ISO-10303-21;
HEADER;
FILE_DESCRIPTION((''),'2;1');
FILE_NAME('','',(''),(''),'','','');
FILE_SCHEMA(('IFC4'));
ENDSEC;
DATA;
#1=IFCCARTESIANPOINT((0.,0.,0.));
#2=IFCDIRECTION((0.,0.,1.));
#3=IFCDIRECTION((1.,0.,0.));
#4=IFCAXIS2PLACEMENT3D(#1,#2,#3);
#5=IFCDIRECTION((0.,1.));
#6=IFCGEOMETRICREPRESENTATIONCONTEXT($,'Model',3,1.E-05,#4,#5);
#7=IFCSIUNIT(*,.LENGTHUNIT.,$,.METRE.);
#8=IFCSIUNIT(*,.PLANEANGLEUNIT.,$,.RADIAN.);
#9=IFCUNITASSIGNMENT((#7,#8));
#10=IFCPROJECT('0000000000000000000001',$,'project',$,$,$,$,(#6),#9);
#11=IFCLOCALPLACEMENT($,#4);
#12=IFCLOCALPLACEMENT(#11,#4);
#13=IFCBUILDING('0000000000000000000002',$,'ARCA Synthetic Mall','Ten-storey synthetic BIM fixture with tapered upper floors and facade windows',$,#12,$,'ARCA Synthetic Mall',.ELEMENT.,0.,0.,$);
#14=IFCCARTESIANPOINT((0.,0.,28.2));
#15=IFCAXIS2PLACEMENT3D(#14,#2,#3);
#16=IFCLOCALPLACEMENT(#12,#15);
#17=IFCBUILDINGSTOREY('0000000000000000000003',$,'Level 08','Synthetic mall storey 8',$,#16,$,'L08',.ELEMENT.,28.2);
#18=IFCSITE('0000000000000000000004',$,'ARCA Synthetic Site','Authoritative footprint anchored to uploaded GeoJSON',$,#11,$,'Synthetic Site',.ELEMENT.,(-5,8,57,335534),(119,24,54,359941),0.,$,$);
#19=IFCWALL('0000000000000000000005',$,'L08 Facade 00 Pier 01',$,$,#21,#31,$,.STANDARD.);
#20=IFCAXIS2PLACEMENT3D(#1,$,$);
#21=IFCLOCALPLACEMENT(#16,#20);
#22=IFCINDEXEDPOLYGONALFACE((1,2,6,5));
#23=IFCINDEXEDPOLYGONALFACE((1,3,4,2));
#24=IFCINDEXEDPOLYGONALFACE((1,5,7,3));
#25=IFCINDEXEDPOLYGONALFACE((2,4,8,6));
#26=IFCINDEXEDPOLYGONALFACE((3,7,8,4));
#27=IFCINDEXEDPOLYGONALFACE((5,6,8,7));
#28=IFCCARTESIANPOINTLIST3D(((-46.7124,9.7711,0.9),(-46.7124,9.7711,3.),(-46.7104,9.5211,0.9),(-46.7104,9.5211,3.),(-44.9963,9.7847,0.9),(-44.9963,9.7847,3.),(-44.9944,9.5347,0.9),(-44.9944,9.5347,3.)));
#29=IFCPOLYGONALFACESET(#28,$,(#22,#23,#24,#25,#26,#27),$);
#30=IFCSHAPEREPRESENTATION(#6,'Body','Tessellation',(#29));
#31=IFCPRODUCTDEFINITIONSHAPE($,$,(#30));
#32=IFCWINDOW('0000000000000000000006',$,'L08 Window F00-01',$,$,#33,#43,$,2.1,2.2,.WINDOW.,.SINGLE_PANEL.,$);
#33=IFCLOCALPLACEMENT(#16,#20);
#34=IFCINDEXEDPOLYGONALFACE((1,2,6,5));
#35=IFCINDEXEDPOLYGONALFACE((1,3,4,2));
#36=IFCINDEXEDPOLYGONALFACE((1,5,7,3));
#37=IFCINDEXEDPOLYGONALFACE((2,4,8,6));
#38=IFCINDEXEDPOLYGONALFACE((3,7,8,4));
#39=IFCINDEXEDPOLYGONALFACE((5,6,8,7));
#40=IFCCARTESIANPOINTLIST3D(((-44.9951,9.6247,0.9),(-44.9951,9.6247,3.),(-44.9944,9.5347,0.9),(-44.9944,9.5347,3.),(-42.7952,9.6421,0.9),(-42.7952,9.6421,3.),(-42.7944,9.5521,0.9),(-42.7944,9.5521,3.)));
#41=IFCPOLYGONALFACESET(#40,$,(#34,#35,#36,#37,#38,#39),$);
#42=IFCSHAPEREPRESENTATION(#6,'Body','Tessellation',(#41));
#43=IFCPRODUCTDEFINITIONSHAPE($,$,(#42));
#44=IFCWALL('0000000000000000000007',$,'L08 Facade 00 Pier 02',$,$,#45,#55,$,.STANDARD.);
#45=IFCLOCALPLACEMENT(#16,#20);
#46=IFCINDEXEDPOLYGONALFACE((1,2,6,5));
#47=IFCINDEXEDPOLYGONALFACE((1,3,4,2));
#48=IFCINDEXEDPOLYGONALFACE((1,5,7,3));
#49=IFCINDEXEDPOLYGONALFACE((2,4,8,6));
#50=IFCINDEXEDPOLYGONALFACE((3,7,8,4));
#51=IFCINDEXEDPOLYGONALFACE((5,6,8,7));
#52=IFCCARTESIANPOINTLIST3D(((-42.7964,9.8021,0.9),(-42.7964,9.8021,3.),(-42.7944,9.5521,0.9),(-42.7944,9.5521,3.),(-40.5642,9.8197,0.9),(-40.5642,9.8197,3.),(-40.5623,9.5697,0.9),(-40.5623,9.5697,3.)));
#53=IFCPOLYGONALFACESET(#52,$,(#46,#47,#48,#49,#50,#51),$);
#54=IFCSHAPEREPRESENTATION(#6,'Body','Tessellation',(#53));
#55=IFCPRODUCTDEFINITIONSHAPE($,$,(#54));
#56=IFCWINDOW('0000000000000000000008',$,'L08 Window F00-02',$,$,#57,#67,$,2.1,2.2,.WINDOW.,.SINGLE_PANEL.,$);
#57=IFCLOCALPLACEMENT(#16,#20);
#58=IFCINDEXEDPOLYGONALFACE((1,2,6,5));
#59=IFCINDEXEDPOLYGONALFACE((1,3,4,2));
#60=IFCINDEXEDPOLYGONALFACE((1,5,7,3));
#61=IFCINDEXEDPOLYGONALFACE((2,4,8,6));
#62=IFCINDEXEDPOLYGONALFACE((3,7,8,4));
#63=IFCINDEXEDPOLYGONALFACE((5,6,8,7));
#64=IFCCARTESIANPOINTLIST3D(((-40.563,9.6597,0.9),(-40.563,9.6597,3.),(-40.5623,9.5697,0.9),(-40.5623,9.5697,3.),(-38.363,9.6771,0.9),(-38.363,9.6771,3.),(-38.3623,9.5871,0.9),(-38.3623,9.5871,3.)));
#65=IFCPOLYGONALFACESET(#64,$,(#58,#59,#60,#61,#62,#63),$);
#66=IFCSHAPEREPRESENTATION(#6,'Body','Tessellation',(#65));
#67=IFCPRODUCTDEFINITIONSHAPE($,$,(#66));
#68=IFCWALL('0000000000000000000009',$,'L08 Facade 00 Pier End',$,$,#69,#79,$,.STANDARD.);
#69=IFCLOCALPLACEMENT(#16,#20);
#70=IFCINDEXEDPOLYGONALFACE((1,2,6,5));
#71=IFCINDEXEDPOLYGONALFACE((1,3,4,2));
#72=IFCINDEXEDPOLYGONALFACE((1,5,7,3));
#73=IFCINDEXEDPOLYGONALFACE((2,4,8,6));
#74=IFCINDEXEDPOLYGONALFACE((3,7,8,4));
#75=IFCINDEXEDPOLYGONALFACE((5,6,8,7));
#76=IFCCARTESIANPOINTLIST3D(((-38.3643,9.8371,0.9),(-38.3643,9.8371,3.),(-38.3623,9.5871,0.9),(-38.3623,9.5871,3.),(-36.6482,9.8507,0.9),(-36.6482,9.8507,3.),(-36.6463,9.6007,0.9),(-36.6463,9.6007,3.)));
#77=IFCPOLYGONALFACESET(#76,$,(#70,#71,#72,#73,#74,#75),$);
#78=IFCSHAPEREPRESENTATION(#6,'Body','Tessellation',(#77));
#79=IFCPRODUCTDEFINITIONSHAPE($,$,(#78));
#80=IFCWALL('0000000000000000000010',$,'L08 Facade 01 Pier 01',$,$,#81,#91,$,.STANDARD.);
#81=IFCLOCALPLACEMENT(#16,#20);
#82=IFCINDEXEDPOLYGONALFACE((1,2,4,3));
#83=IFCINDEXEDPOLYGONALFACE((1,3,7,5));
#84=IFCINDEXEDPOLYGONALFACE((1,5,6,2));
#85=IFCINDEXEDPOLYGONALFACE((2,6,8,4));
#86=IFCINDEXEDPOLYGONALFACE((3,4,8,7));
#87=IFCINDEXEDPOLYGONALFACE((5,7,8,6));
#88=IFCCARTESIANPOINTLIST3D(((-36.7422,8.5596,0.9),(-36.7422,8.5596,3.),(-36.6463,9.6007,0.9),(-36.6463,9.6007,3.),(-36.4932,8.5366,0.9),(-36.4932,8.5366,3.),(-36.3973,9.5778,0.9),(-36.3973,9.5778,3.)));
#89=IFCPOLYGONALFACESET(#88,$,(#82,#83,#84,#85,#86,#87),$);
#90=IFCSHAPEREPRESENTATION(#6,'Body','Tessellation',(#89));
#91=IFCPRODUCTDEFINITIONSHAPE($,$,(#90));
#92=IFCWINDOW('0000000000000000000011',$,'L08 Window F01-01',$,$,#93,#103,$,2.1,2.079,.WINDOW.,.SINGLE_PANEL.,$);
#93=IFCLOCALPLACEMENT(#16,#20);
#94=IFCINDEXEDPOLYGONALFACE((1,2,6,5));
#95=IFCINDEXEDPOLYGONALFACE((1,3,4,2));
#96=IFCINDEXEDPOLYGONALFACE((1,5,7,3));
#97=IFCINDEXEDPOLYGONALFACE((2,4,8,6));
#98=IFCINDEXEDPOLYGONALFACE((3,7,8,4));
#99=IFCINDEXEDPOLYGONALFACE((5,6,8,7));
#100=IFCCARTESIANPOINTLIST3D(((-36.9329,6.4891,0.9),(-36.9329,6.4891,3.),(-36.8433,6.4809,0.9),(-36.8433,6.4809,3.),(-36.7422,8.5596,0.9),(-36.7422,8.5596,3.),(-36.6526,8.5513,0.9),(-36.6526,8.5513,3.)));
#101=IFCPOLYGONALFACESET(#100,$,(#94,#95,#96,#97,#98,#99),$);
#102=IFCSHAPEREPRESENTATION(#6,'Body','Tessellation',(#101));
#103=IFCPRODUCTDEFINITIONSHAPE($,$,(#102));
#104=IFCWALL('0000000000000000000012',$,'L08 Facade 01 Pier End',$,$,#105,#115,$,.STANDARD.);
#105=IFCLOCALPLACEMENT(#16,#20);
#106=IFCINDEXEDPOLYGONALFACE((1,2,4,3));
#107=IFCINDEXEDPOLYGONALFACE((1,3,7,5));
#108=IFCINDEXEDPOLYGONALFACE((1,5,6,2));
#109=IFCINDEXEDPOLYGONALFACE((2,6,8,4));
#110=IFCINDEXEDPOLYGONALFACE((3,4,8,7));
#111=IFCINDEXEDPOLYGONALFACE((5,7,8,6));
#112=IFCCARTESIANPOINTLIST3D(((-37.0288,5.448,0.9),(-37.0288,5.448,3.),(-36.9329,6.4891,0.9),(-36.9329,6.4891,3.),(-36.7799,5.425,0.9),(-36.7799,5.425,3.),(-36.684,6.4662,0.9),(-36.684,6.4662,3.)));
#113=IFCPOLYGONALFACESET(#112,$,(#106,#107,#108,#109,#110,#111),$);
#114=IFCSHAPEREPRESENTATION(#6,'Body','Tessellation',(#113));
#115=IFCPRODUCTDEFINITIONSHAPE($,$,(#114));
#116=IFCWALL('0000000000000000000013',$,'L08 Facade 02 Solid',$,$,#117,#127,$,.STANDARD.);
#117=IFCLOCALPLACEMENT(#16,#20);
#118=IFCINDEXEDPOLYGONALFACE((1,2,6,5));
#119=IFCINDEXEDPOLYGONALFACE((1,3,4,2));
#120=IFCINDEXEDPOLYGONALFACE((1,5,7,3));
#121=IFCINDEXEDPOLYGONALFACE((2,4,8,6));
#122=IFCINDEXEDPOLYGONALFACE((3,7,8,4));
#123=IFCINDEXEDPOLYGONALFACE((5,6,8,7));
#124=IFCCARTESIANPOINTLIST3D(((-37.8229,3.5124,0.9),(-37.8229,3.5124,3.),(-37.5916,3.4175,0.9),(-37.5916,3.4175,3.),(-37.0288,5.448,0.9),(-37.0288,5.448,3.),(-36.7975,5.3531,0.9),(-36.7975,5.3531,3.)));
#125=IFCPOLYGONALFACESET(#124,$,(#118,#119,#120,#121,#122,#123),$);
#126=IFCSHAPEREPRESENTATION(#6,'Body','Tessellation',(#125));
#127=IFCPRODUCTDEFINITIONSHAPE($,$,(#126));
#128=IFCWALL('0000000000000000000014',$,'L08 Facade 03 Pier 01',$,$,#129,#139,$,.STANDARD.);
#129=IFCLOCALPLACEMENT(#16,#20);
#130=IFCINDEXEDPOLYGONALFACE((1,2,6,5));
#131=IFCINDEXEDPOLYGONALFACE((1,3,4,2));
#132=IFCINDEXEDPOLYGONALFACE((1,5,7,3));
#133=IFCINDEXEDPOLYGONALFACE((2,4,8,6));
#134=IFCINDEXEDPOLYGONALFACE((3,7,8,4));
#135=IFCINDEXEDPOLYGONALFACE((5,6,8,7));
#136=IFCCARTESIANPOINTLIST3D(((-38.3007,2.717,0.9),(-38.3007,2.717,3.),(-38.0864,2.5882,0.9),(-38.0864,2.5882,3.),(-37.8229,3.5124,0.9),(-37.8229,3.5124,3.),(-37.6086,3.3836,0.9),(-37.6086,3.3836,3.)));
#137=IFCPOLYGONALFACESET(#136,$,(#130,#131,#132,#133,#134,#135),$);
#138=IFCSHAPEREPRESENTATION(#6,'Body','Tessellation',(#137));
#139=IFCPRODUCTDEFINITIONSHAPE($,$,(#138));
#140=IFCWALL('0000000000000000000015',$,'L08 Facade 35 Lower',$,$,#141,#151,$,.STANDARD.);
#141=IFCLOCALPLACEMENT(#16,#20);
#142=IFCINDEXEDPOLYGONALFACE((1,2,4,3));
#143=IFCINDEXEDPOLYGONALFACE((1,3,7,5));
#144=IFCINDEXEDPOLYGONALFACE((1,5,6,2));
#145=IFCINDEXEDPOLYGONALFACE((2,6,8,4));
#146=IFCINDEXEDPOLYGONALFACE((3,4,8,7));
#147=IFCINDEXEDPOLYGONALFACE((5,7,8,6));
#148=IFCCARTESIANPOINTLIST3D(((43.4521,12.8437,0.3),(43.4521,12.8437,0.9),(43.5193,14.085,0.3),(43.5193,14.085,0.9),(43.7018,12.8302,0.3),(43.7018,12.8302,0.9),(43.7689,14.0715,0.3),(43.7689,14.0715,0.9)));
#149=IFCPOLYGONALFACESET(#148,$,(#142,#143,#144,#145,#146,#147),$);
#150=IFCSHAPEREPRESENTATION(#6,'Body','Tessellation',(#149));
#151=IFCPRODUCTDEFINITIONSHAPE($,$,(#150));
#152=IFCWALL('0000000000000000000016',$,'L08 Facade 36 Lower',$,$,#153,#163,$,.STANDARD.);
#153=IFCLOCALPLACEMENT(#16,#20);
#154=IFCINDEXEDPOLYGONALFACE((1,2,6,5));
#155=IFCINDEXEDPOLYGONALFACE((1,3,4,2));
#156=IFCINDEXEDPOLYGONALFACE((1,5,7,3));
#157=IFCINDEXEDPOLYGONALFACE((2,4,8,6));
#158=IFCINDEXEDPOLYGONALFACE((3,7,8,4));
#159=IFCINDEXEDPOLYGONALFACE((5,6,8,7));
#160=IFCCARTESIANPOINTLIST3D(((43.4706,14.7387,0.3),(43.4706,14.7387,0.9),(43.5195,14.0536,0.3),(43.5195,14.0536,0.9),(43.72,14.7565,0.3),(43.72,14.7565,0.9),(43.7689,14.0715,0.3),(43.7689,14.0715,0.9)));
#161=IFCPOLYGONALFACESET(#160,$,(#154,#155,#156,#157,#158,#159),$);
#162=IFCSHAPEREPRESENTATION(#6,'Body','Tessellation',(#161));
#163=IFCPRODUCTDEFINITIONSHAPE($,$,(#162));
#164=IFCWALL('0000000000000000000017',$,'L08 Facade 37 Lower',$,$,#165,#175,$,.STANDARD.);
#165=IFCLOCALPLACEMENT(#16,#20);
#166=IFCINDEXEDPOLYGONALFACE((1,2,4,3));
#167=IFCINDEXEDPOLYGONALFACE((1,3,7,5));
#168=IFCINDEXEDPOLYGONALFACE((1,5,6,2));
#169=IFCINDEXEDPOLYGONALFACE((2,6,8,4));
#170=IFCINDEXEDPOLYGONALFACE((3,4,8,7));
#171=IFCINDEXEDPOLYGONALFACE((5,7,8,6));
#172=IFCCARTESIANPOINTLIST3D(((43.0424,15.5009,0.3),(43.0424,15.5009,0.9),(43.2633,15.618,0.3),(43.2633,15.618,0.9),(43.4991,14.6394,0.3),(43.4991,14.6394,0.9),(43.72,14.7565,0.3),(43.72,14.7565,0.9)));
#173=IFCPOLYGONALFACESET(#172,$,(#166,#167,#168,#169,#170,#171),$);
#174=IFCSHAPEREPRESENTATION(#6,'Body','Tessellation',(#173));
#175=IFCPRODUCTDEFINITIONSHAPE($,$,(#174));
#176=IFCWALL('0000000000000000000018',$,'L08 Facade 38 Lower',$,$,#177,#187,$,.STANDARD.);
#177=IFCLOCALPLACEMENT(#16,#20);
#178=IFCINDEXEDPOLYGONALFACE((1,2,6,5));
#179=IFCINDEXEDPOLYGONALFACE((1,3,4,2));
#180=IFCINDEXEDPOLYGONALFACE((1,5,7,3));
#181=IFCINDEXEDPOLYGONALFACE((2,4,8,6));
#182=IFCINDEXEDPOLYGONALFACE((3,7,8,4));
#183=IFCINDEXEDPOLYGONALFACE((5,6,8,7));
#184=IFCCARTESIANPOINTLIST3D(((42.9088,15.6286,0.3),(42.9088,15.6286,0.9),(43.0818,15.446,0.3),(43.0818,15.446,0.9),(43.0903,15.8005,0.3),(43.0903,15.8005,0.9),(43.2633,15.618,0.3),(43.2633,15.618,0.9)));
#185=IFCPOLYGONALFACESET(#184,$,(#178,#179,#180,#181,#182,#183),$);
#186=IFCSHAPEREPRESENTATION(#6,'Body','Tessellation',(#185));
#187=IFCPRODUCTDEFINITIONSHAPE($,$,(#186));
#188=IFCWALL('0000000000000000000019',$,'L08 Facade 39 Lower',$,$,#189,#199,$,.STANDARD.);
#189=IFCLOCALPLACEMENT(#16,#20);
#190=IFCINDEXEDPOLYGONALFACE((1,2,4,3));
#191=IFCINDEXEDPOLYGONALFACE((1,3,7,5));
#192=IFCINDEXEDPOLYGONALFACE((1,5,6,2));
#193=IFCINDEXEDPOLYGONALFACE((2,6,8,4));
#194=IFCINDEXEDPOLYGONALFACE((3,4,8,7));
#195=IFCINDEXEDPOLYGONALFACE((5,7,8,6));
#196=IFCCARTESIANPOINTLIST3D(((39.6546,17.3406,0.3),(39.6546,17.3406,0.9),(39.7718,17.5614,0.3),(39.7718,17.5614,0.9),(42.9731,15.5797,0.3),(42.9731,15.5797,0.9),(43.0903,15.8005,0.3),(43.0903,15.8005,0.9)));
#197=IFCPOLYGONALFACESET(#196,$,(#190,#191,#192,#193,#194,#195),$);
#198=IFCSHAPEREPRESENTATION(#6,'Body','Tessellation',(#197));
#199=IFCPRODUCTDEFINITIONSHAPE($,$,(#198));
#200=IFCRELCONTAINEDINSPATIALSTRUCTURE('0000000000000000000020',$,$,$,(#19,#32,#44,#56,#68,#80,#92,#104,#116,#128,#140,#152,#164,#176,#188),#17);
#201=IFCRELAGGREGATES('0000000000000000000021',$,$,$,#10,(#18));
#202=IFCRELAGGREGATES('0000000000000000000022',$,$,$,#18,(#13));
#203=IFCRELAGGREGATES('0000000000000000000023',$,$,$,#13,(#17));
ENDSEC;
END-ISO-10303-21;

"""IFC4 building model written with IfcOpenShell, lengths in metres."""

from ifc_helpers import new_model, si_unit, direction, frame, origin_with_axes, place, context, project, spatial, polyline, outline, extrude, element, save


model = new_model("IFC4")

# Units and contexts
model_context = context("Model", 3, precision=1e-05, world=origin_with_axes(), true_north=direction((0.0, 1.0)))
ifc_project = project(units=[si_unit("LENGTHUNIT", "METRE"), si_unit("PLANEANGLEUNIT", "RADIAN")], contexts=[model_context])

# Site, building, storey
site_placement = place(None, origin_with_axes())
site = spatial("IfcSite", under=ifc_project, at=site_placement, Name="ARCA Synthetic Site", Description="Authoritative footprint anchored to uploaded GeoJSON", LongName="Synthetic Site", CompositionType="ELEMENT", RefLatitude=(-5, 8, 57, 335534), RefLongitude=(119, 24, 54, 359941), RefElevation=0.0)
building_placement = place(site_placement, origin_with_axes())
building = spatial("IfcBuilding", under=site, at=building_placement, Name="ARCA Synthetic Mall", Description="Ten-storey synthetic BIM fixture with tapered upper floors and facade windows", LongName="ARCA Synthetic Mall", CompositionType="ELEMENT", ElevationOfRefHeight=0.0, ElevationOfTerrain=0.0)
storey_placement = place(building_placement, frame((0.0, 0.0, 28.2), z_axis=(0.0, 0.0, 1.0), x_axis=(1.0, 0.0, 0.0)))
storey = spatial("IfcBuildingStorey", under=building, at=storey_placement, Name="Level 08", Description="Synthetic mall storey 8", LongName="L08", CompositionType="ELEMENT", Elevation=28.2)

# Wall
wall_1_placement = place(storey_placement, frame((0.0, 0.0, 0.9), z_axis=(0.0, 0.0, 1.0), x_axis=(1.0, 0.0, 0.0)))
element("IfcWall", 1, at=wall_1_placement, inside=storey, Name="L08 Facade 00 Pier 01", PredefinedType="STANDARD", context=model_context, shape_type="SweptSolid", body=[
    extrude(outline(polyline([(-46.7104, 9.5211), (-44.9944, 9.5347), (-44.9963, 9.7847), (-46.7124, 9.7711), (-46.7104, 9.5211)])), origin_with_axes(), (0.0, 0.0, 1.0), 2.1),
])

# Window
window_1_placement = place(storey_placement, frame((0.0, 0.0, 0.9), z_axis=(0.0, 0.0, 1.0), x_axis=(1.0, 0.0, 0.0)))
element("IfcWindow", 2, at=window_1_placement, inside=storey, Name="L08 Window F00-01", OverallHeight=2.1, OverallWidth=2.2, PartitioningType="SINGLE_PANEL", PredefinedType="WINDOW", context=model_context, shape_type="SweptSolid", body=[
    extrude(outline(polyline([(-44.9944, 9.5347), (-42.7944, 9.5521), (-42.7952, 9.6421), (-44.9951, 9.6247), (-44.9944, 9.5347)])), origin_with_axes(), (0.0, 0.0, 1.0), 2.1),
])

# Wall
wall_2_placement = place(storey_placement, frame((0.0, 0.0, 0.9), z_axis=(0.0, 0.0, 1.0), x_axis=(1.0, 0.0, 0.0)))
element("IfcWall", 3, at=wall_2_placement, inside=storey, Name="L08 Facade 00 Pier 02", PredefinedType="STANDARD", context=model_context, shape_type="SweptSolid", body=[
    extrude(outline(polyline([(-42.7944, 9.5521), (-40.5623, 9.5697), (-40.5642, 9.8197), (-42.7964, 9.8021), (-42.7944, 9.5521)])), origin_with_axes(), (0.0, 0.0, 1.0), 2.1),
])

# Window
window_2_placement = place(storey_placement, frame((0.0, 0.0, 0.9), z_axis=(0.0, 0.0, 1.0), x_axis=(1.0, 0.0, 0.0)))
element("IfcWindow", 4, at=window_2_placement, inside=storey, Name="L08 Window F00-02", OverallHeight=2.1, OverallWidth=2.2, PartitioningType="SINGLE_PANEL", PredefinedType="WINDOW", context=model_context, shape_type="SweptSolid", body=[
    extrude(outline(polyline([(-40.5623, 9.5697), (-38.3623, 9.5871), (-38.363, 9.6771), (-40.563, 9.6597), (-40.5623, 9.5697)])), origin_with_axes(), (0.0, 0.0, 1.0), 2.1),
])

# Walls
wall_3_placement = place(storey_placement, frame((0.0, 0.0, 0.9), z_axis=(0.0, 0.0, 1.0), x_axis=(1.0, 0.0, 0.0)))
element("IfcWall", 5, at=wall_3_placement, inside=storey, Name="L08 Facade 00 Pier End", PredefinedType="STANDARD", context=model_context, shape_type="SweptSolid", body=[
    extrude(outline(polyline([(-38.3623, 9.5871), (-36.6463, 9.6007), (-36.6482, 9.8507), (-38.3643, 9.8371), (-38.3623, 9.5871)])), origin_with_axes(), (0.0, 0.0, 1.0), 2.1),
])
wall_4_placement = place(storey_placement, frame((0.0, 0.0, 0.9), z_axis=(0.0, 0.0, 1.0), x_axis=(1.0, 0.0, 0.0)))
element("IfcWall", 6, at=wall_4_placement, inside=storey, Name="L08 Facade 01 Pier 01", PredefinedType="STANDARD", context=model_context, shape_type="SweptSolid", body=[
    extrude(outline(polyline([(-36.6463, 9.6007), (-36.7422, 8.5596), (-36.4932, 8.5366), (-36.3973, 9.5778), (-36.6463, 9.6007)])), origin_with_axes(), (0.0, 0.0, 1.0), 2.1),
])

# Window
window_3_placement = place(storey_placement, frame((0.0, 0.0, 0.9), z_axis=(0.0, 0.0, 1.0), x_axis=(1.0, 0.0, 0.0)))
element("IfcWindow", 7, at=window_3_placement, inside=storey, Name="L08 Window F01-01", OverallHeight=2.1, OverallWidth=2.079, PartitioningType="SINGLE_PANEL", PredefinedType="WINDOW", context=model_context, shape_type="SweptSolid", body=[
    extrude(outline(polyline([(-36.7422, 8.5596), (-36.9329, 6.4891), (-36.8433, 6.4809), (-36.6526, 8.5513), (-36.7422, 8.5596)])), origin_with_axes(), (0.0, 0.0, 1.0), 2.1),
])

# Walls
wall_5_placement = place(storey_placement, frame((0.0, 0.0, 0.9), z_axis=(0.0, 0.0, 1.0), x_axis=(1.0, 0.0, 0.0)))
element("IfcWall", 8, at=wall_5_placement, inside=storey, Name="L08 Facade 01 Pier End", PredefinedType="STANDARD", context=model_context, shape_type="SweptSolid", body=[
    extrude(outline(polyline([(-36.9329, 6.4891), (-37.0288, 5.448), (-36.7799, 5.425), (-36.684, 6.4662), (-36.9329, 6.4891)])), origin_with_axes(), (0.0, 0.0, 1.0), 2.1),
])
wall_6_placement = place(storey_placement, frame((0.0, 0.0, 0.9), z_axis=(0.0, 0.0, 1.0), x_axis=(1.0, 0.0, 0.0)))
element("IfcWall", 9, at=wall_6_placement, inside=storey, Name="L08 Facade 02 Solid", PredefinedType="STANDARD", context=model_context, shape_type="SweptSolid", body=[
    extrude(outline(polyline([(-37.0288, 5.448), (-37.8229, 3.5124), (-37.5916, 3.4175), (-36.7975, 5.3531), (-37.0288, 5.448)])), origin_with_axes(), (0.0, 0.0, 1.0), 2.1),
])
wall_7_placement = place(storey_placement, frame((0.0, 0.0, 0.9), z_axis=(0.0, 0.0, 1.0), x_axis=(1.0, 0.0, 0.0)))
element("IfcWall", 10, at=wall_7_placement, inside=storey, Name="L08 Facade 03 Pier 01", PredefinedType="STANDARD", context=model_context, shape_type="SweptSolid", body=[
    extrude(outline(polyline([(-37.8229, 3.5124), (-38.3007, 2.717), (-38.0864, 2.5882), (-37.6086, 3.3836), (-37.8229, 3.5124)])), origin_with_axes(), (0.0, 0.0, 1.0), 2.1),
])
wall_8_placement = place(storey_placement, frame((0.0, 0.0, 0.3), z_axis=(0.0, 0.0, 1.0), x_axis=(1.0, 0.0, 0.0)))
element("IfcWall", 11, at=wall_8_placement, inside=storey, Name="L08 Facade 35 Lower", PredefinedType="STANDARD", context=model_context, shape_type="SweptSolid", body=[
    extrude(outline(polyline([(43.7018, 12.8302), (43.7689, 14.0715), (43.5193, 14.085), (43.4521, 12.8437), (43.7018, 12.8302)])), origin_with_axes(), (0.0, 0.0, 1.0), 0.6),
])
wall_9_placement = place(storey_placement, frame((0.0, 0.0, 0.3), z_axis=(0.0, 0.0, 1.0), x_axis=(1.0, 0.0, 0.0)))
element("IfcWall", 12, at=wall_9_placement, inside=storey, Name="L08 Facade 36 Lower", PredefinedType="STANDARD", context=model_context, shape_type="SweptSolid", body=[
    extrude(outline(polyline([(43.7689, 14.0715), (43.72, 14.7565), (43.4706, 14.7387), (43.5195, 14.0536), (43.7689, 14.0715)])), origin_with_axes(), (0.0, 0.0, 1.0), 0.6),
])
wall_10_placement = place(storey_placement, frame((0.0, 0.0, 0.3), z_axis=(0.0, 0.0, 1.0), x_axis=(1.0, 0.0, 0.0)))
element("IfcWall", 13, at=wall_10_placement, inside=storey, Name="L08 Facade 37 Lower", PredefinedType="STANDARD", context=model_context, shape_type="SweptSolid", body=[
    extrude(outline(polyline([(43.72, 14.7565), (43.2633, 15.618), (43.0424, 15.5009), (43.4991, 14.6394), (43.72, 14.7565)])), origin_with_axes(), (0.0, 0.0, 1.0), 0.6),
])
wall_11_placement = place(storey_placement, frame((0.0, 0.0, 0.3), z_axis=(0.0, 0.0, 1.0), x_axis=(1.0, 0.0, 0.0)))
element("IfcWall", 14, at=wall_11_placement, inside=storey, Name="L08 Facade 38 Lower", PredefinedType="STANDARD", context=model_context, shape_type="SweptSolid", body=[
    extrude(outline(polyline([(43.2633, 15.618), (43.0903, 15.8005), (42.9088, 15.6286), (43.0818, 15.446), (43.2633, 15.618)])), origin_with_axes(), (0.0, 0.0, 1.0), 0.6),
])
wall_12_placement = place(storey_placement, frame((0.0, 0.0, 0.3), z_axis=(0.0, 0.0, 1.0), x_axis=(1.0, 0.0, 0.0)))
element("IfcWall", 15, at=wall_12_placement, inside=storey, Name="L08 Facade 39 Lower", PredefinedType="STANDARD", context=model_context, shape_type="SweptSolid", body=[
    extrude(outline(polyline([(43.0903, 15.8005), (39.7718, 17.5614), (39.6546, 17.3406), (42.9731, 15.5797), (43.0903, 15.8005)])), origin_with_axes(), (0.0, 0.0, 1.0), 0.6),
])

save(model, "model.ifc")
